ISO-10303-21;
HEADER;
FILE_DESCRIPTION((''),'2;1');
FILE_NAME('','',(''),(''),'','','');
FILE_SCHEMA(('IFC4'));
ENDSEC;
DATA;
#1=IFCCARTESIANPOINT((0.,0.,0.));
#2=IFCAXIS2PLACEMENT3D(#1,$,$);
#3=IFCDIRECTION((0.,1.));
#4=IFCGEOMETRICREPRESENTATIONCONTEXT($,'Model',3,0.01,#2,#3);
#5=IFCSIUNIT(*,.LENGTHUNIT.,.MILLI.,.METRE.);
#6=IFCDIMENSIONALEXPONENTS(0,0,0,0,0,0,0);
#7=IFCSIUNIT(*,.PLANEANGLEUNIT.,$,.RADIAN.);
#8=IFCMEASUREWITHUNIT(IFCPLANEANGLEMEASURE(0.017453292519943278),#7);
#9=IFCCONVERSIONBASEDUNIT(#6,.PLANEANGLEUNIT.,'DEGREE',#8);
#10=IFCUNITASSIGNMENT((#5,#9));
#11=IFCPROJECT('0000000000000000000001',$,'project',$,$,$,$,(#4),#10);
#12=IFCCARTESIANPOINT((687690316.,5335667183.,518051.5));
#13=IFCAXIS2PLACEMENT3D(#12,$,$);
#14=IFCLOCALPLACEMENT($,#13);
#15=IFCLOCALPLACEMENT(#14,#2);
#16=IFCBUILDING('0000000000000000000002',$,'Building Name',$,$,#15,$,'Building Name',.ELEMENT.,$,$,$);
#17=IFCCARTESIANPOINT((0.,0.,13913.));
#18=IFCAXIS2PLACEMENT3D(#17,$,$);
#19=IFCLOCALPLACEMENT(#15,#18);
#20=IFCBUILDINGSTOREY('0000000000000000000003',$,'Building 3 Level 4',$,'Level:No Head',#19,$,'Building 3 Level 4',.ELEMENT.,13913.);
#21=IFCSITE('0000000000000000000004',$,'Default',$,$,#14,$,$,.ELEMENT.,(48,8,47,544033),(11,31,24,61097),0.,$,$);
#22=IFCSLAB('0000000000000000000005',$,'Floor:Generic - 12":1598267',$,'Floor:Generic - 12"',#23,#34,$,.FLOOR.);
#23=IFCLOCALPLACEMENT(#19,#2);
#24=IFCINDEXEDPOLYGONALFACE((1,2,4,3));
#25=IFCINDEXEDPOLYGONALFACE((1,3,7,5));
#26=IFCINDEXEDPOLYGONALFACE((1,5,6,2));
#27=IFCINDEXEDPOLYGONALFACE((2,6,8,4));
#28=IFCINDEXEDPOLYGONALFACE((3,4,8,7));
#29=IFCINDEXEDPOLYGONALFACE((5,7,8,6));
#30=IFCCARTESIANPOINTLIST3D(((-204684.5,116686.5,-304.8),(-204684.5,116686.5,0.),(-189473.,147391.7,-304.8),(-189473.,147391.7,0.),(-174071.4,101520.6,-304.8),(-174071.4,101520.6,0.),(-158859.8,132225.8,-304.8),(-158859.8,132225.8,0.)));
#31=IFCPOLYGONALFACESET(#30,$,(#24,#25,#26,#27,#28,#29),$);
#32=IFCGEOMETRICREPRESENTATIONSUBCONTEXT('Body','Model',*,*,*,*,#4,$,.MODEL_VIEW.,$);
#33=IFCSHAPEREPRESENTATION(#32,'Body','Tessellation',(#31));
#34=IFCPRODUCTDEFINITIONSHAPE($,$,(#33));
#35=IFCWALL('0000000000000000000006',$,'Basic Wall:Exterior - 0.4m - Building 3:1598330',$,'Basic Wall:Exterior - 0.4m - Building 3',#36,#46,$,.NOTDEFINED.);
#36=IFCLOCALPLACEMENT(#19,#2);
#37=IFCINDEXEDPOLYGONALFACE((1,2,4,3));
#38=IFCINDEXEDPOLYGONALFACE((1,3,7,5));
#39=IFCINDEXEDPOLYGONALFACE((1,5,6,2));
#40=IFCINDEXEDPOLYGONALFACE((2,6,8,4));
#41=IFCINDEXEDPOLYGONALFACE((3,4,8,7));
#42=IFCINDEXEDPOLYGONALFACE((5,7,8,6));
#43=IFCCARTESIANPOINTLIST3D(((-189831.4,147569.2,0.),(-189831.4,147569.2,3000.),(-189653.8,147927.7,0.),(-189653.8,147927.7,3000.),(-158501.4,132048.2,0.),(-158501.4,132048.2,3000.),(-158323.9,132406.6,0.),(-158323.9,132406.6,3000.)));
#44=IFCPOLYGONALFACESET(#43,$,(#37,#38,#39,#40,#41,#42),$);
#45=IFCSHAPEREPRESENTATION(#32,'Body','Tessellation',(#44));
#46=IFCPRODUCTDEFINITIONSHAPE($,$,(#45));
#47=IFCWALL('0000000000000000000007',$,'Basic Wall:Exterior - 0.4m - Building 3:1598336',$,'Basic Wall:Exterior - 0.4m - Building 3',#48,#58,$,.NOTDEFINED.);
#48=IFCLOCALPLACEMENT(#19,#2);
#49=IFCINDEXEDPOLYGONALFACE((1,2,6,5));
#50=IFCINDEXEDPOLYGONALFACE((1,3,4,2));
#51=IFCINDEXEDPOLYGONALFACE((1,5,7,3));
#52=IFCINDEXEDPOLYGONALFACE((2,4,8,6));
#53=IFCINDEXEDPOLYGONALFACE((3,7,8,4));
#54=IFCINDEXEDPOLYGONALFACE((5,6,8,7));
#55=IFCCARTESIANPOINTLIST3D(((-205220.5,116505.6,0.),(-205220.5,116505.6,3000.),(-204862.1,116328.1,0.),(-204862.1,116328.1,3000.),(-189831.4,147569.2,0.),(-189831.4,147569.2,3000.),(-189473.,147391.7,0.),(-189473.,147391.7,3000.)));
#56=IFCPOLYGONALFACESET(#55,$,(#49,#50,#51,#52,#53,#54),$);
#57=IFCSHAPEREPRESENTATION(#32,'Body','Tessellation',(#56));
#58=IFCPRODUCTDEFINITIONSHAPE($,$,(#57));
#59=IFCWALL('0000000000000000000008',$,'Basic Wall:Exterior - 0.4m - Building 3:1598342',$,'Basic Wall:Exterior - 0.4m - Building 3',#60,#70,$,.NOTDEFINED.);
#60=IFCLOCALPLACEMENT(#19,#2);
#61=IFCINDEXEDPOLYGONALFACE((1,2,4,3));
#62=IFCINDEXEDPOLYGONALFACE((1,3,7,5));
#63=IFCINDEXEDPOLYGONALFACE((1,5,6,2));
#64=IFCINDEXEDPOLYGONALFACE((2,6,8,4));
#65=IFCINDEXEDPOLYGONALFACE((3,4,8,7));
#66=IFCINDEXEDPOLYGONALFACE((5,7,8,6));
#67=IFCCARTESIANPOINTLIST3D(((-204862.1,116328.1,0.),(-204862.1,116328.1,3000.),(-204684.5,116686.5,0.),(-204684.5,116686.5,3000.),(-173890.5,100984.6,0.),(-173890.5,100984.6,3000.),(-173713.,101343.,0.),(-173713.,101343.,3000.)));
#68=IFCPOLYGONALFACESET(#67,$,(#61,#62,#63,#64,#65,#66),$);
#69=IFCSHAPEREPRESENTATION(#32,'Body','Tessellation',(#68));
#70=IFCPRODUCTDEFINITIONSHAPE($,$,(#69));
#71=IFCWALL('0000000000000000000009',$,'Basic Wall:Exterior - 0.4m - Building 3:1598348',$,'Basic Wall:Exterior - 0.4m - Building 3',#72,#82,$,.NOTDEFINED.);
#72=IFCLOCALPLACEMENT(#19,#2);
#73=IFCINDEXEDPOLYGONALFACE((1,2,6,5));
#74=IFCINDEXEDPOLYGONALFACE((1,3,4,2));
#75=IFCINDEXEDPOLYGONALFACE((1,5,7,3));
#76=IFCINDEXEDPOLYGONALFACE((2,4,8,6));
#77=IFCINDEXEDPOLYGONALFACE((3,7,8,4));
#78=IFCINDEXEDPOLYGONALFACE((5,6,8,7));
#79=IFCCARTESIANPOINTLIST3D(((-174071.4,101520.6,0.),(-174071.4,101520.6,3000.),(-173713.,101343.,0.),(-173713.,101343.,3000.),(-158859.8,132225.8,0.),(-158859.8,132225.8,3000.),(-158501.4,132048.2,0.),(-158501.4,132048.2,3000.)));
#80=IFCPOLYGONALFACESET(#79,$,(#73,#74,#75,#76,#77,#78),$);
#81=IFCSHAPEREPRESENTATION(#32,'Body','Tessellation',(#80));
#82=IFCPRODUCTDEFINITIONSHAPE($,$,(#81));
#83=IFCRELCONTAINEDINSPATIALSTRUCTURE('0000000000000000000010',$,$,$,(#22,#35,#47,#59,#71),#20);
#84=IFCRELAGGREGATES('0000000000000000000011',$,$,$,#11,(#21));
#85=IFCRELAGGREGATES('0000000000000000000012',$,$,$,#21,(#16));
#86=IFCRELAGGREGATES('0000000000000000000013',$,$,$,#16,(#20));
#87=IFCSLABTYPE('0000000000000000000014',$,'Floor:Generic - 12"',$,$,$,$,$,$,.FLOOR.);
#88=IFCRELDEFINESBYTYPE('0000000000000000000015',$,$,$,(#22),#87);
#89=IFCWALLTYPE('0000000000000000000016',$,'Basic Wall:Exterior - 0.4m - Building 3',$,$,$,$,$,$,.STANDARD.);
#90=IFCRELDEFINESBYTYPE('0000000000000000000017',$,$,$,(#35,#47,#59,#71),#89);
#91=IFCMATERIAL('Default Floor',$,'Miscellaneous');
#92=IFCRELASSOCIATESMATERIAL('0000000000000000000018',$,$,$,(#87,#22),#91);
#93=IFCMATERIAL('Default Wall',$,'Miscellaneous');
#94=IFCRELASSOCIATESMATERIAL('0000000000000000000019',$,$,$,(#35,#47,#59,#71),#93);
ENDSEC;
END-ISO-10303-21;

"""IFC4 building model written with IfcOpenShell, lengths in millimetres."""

from ifc_helpers import new_model, entity, si_unit, converted_unit, direction, frame, origin, place, context, subcontext, project, spatial, indexed_curve, outline, extrude, material, type_object, element, save


model = new_model("IFC4")

# Units and contexts
model_context = context("Model", 3, precision=0.01, world=origin(), true_north=direction((0.0, 1.0)))
body_context = subcontext(model_context, "Body", "Model", "MODEL_VIEW")
ifc_project = project(units=[si_unit("LENGTHUNIT", "METRE", prefix="MILLI"), converted_unit("PLANEANGLEUNIT", "DEGREE", entity("IfcPlaneAngleMeasure", 0.017453292519943278), si_unit("PLANEANGLEUNIT", "RADIAN"), dimensions=[0, 0, 0, 0, 0, 0, 0])], contexts=[model_context])

# Site, building, storey
site_placement = place(None, frame((687690316.0, 5335667183.0, 518051.5)))
site = spatial("IfcSite", under=ifc_project, at=site_placement, Name="Default", CompositionType="ELEMENT", RefLatitude=(48, 8, 47, 544033), RefLongitude=(11, 31, 24, 61097), RefElevation=0.0)
building_placement = place(site_placement, origin())
building = spatial("IfcBuilding", under=site, at=building_placement, Name="Building Name", LongName="Building Name", CompositionType="ELEMENT")
storey_placement = place(building_placement, frame((0.0, 0.0, 13913.0)))
storey = spatial("IfcBuildingStorey", under=building, at=storey_placement, Name="Building 3 Level 4", ObjectType="Level:No Head", LongName="Building 3 Level 4", CompositionType="ELEMENT", Elevation=13913.0)

# Slab
ifc_material_1 = material(Name="Default Floor", Category="Miscellaneous")
slab_type = type_object("IfcSlabType", Name="Floor:Generic - 12\"", PredefinedType="FLOOR", material=ifc_material_1)
slab_placement = place(storey_placement, origin())
element("IfcSlab", 1, at=slab_placement, inside=storey, type_object=slab_type, material=ifc_material_1, Name="Floor:Generic - 12\":1598267", ObjectType="Floor:Generic - 12\"", PredefinedType="FLOOR", context=body_context, shape_type="SweptSolid", body=[
    extrude(outline(indexed_curve([(-17081.9, -17133.3), (17081.9, -17133.3), (17081.9, 17133.3), (-17081.9, 17133.3), (-17081.9, -17133.3)], self_intersect=False)), frame((-181772.2, 124456.1, 0.0), z_axis=(0.0, 0.0, -1.0), x_axis=(0.896068, -0.443917, 0.0)), (0.0, 0.0, 1.0), 304.8),
])

# Walls
ifc_material_2 = material(Name="Default Wall", Category="Miscellaneous")
wall_type = type_object("IfcWallType", Name="Basic Wall:Exterior - 0.4m - Building 3", PredefinedType="STANDARD")
wall_1_placement = place(storey_placement, frame((-158412.6, 132227.4, 0.0), z_axis=(0.0, 0.0, 1.0), x_axis=(-0.896068, 0.443917, 0.0)))
element("IfcWall", 2, at=wall_1_placement, inside=storey, type_object=wall_type, material=ifc_material_2, Name="Basic Wall:Exterior - 0.4m - Building 3:1598330", ObjectType="Basic Wall:Exterior - 0.4m - Building 3", PredefinedType="NOTDEFINED", context=body_context, shape_type="SweptSolid", body=[
    extrude(outline(indexed_curve([(34963.8, 200.0), (0.0, 200.0), (0.0, -200.0), (34963.8, -200.0), (34963.8, 200.0)], self_intersect=False)), origin(), (0.0, 0.0, 1.0), 3000.0),
])
wall_2_placement = place(storey_placement, frame((-189652.2, 147480.5, 0.0), z_axis=(0.0, 0.0, 1.0), x_axis=(-0.443917, -0.896068, 0.0)))
element("IfcWall", 3, at=wall_2_placement, inside=storey, type_object=wall_type, material=ifc_material_2, Name="Basic Wall:Exterior - 0.4m - Building 3:1598336", ObjectType="Basic Wall:Exterior - 0.4m - Building 3", PredefinedType="NOTDEFINED", context=body_context, shape_type="SweptSolid", body=[
    extrude(outline(indexed_curve([(34666.6, 200.0), (0.0, 200.0), (0.0, -200.0), (34666.6, -200.0), (34666.6, 200.0)], self_intersect=False)), origin(), (0.0, 0.0, 1.0), 3000.0),
])
wall_3_placement = place(storey_placement, frame((-204773.3, 116507.3, 0.0), z_axis=(0.0, 0.0, 1.0), x_axis=(0.896068, -0.443917, 0.0)))
element("IfcWall", 4, at=wall_3_placement, inside=storey, type_object=wall_type, material=ifc_material_2, Name="Basic Wall:Exterior - 0.4m - Building 3:1598342", ObjectType="Basic Wall:Exterior - 0.4m - Building 3", PredefinedType="NOTDEFINED", context=body_context, shape_type="SweptSolid", body=[
    extrude(outline(indexed_curve([(34563.8, 200.0), (0.0, 200.0), (0.0, -200.0), (34563.8, -200.0), (34563.8, 200.0)], self_intersect=False)), origin(), (0.0, 0.0, 1.0), 3000.0),
])
wall_4_placement = place(storey_placement, frame((-173892.2, 101431.8, 0.0), z_axis=(0.0, 0.0, 1.0), x_axis=(0.443917, 0.896068, 0.0)))
element("IfcWall", 5, at=wall_4_placement, inside=storey, type_object=wall_type, material=ifc_material_2, Name="Basic Wall:Exterior - 0.4m - Building 3:1598348", ObjectType="Basic Wall:Exterior - 0.4m - Building 3", PredefinedType="NOTDEFINED", context=body_context, shape_type="SweptSolid", body=[
    extrude(outline(indexed_curve([(34266.6, 200.0), (0.0, 200.0), (0.0, -200.0), (34266.6, -200.0), (34266.6, 200.0)], self_intersect=False)), origin(), (0.0, 0.0, 1.0), 3000.0),
])

save(model, "model.ifc")
